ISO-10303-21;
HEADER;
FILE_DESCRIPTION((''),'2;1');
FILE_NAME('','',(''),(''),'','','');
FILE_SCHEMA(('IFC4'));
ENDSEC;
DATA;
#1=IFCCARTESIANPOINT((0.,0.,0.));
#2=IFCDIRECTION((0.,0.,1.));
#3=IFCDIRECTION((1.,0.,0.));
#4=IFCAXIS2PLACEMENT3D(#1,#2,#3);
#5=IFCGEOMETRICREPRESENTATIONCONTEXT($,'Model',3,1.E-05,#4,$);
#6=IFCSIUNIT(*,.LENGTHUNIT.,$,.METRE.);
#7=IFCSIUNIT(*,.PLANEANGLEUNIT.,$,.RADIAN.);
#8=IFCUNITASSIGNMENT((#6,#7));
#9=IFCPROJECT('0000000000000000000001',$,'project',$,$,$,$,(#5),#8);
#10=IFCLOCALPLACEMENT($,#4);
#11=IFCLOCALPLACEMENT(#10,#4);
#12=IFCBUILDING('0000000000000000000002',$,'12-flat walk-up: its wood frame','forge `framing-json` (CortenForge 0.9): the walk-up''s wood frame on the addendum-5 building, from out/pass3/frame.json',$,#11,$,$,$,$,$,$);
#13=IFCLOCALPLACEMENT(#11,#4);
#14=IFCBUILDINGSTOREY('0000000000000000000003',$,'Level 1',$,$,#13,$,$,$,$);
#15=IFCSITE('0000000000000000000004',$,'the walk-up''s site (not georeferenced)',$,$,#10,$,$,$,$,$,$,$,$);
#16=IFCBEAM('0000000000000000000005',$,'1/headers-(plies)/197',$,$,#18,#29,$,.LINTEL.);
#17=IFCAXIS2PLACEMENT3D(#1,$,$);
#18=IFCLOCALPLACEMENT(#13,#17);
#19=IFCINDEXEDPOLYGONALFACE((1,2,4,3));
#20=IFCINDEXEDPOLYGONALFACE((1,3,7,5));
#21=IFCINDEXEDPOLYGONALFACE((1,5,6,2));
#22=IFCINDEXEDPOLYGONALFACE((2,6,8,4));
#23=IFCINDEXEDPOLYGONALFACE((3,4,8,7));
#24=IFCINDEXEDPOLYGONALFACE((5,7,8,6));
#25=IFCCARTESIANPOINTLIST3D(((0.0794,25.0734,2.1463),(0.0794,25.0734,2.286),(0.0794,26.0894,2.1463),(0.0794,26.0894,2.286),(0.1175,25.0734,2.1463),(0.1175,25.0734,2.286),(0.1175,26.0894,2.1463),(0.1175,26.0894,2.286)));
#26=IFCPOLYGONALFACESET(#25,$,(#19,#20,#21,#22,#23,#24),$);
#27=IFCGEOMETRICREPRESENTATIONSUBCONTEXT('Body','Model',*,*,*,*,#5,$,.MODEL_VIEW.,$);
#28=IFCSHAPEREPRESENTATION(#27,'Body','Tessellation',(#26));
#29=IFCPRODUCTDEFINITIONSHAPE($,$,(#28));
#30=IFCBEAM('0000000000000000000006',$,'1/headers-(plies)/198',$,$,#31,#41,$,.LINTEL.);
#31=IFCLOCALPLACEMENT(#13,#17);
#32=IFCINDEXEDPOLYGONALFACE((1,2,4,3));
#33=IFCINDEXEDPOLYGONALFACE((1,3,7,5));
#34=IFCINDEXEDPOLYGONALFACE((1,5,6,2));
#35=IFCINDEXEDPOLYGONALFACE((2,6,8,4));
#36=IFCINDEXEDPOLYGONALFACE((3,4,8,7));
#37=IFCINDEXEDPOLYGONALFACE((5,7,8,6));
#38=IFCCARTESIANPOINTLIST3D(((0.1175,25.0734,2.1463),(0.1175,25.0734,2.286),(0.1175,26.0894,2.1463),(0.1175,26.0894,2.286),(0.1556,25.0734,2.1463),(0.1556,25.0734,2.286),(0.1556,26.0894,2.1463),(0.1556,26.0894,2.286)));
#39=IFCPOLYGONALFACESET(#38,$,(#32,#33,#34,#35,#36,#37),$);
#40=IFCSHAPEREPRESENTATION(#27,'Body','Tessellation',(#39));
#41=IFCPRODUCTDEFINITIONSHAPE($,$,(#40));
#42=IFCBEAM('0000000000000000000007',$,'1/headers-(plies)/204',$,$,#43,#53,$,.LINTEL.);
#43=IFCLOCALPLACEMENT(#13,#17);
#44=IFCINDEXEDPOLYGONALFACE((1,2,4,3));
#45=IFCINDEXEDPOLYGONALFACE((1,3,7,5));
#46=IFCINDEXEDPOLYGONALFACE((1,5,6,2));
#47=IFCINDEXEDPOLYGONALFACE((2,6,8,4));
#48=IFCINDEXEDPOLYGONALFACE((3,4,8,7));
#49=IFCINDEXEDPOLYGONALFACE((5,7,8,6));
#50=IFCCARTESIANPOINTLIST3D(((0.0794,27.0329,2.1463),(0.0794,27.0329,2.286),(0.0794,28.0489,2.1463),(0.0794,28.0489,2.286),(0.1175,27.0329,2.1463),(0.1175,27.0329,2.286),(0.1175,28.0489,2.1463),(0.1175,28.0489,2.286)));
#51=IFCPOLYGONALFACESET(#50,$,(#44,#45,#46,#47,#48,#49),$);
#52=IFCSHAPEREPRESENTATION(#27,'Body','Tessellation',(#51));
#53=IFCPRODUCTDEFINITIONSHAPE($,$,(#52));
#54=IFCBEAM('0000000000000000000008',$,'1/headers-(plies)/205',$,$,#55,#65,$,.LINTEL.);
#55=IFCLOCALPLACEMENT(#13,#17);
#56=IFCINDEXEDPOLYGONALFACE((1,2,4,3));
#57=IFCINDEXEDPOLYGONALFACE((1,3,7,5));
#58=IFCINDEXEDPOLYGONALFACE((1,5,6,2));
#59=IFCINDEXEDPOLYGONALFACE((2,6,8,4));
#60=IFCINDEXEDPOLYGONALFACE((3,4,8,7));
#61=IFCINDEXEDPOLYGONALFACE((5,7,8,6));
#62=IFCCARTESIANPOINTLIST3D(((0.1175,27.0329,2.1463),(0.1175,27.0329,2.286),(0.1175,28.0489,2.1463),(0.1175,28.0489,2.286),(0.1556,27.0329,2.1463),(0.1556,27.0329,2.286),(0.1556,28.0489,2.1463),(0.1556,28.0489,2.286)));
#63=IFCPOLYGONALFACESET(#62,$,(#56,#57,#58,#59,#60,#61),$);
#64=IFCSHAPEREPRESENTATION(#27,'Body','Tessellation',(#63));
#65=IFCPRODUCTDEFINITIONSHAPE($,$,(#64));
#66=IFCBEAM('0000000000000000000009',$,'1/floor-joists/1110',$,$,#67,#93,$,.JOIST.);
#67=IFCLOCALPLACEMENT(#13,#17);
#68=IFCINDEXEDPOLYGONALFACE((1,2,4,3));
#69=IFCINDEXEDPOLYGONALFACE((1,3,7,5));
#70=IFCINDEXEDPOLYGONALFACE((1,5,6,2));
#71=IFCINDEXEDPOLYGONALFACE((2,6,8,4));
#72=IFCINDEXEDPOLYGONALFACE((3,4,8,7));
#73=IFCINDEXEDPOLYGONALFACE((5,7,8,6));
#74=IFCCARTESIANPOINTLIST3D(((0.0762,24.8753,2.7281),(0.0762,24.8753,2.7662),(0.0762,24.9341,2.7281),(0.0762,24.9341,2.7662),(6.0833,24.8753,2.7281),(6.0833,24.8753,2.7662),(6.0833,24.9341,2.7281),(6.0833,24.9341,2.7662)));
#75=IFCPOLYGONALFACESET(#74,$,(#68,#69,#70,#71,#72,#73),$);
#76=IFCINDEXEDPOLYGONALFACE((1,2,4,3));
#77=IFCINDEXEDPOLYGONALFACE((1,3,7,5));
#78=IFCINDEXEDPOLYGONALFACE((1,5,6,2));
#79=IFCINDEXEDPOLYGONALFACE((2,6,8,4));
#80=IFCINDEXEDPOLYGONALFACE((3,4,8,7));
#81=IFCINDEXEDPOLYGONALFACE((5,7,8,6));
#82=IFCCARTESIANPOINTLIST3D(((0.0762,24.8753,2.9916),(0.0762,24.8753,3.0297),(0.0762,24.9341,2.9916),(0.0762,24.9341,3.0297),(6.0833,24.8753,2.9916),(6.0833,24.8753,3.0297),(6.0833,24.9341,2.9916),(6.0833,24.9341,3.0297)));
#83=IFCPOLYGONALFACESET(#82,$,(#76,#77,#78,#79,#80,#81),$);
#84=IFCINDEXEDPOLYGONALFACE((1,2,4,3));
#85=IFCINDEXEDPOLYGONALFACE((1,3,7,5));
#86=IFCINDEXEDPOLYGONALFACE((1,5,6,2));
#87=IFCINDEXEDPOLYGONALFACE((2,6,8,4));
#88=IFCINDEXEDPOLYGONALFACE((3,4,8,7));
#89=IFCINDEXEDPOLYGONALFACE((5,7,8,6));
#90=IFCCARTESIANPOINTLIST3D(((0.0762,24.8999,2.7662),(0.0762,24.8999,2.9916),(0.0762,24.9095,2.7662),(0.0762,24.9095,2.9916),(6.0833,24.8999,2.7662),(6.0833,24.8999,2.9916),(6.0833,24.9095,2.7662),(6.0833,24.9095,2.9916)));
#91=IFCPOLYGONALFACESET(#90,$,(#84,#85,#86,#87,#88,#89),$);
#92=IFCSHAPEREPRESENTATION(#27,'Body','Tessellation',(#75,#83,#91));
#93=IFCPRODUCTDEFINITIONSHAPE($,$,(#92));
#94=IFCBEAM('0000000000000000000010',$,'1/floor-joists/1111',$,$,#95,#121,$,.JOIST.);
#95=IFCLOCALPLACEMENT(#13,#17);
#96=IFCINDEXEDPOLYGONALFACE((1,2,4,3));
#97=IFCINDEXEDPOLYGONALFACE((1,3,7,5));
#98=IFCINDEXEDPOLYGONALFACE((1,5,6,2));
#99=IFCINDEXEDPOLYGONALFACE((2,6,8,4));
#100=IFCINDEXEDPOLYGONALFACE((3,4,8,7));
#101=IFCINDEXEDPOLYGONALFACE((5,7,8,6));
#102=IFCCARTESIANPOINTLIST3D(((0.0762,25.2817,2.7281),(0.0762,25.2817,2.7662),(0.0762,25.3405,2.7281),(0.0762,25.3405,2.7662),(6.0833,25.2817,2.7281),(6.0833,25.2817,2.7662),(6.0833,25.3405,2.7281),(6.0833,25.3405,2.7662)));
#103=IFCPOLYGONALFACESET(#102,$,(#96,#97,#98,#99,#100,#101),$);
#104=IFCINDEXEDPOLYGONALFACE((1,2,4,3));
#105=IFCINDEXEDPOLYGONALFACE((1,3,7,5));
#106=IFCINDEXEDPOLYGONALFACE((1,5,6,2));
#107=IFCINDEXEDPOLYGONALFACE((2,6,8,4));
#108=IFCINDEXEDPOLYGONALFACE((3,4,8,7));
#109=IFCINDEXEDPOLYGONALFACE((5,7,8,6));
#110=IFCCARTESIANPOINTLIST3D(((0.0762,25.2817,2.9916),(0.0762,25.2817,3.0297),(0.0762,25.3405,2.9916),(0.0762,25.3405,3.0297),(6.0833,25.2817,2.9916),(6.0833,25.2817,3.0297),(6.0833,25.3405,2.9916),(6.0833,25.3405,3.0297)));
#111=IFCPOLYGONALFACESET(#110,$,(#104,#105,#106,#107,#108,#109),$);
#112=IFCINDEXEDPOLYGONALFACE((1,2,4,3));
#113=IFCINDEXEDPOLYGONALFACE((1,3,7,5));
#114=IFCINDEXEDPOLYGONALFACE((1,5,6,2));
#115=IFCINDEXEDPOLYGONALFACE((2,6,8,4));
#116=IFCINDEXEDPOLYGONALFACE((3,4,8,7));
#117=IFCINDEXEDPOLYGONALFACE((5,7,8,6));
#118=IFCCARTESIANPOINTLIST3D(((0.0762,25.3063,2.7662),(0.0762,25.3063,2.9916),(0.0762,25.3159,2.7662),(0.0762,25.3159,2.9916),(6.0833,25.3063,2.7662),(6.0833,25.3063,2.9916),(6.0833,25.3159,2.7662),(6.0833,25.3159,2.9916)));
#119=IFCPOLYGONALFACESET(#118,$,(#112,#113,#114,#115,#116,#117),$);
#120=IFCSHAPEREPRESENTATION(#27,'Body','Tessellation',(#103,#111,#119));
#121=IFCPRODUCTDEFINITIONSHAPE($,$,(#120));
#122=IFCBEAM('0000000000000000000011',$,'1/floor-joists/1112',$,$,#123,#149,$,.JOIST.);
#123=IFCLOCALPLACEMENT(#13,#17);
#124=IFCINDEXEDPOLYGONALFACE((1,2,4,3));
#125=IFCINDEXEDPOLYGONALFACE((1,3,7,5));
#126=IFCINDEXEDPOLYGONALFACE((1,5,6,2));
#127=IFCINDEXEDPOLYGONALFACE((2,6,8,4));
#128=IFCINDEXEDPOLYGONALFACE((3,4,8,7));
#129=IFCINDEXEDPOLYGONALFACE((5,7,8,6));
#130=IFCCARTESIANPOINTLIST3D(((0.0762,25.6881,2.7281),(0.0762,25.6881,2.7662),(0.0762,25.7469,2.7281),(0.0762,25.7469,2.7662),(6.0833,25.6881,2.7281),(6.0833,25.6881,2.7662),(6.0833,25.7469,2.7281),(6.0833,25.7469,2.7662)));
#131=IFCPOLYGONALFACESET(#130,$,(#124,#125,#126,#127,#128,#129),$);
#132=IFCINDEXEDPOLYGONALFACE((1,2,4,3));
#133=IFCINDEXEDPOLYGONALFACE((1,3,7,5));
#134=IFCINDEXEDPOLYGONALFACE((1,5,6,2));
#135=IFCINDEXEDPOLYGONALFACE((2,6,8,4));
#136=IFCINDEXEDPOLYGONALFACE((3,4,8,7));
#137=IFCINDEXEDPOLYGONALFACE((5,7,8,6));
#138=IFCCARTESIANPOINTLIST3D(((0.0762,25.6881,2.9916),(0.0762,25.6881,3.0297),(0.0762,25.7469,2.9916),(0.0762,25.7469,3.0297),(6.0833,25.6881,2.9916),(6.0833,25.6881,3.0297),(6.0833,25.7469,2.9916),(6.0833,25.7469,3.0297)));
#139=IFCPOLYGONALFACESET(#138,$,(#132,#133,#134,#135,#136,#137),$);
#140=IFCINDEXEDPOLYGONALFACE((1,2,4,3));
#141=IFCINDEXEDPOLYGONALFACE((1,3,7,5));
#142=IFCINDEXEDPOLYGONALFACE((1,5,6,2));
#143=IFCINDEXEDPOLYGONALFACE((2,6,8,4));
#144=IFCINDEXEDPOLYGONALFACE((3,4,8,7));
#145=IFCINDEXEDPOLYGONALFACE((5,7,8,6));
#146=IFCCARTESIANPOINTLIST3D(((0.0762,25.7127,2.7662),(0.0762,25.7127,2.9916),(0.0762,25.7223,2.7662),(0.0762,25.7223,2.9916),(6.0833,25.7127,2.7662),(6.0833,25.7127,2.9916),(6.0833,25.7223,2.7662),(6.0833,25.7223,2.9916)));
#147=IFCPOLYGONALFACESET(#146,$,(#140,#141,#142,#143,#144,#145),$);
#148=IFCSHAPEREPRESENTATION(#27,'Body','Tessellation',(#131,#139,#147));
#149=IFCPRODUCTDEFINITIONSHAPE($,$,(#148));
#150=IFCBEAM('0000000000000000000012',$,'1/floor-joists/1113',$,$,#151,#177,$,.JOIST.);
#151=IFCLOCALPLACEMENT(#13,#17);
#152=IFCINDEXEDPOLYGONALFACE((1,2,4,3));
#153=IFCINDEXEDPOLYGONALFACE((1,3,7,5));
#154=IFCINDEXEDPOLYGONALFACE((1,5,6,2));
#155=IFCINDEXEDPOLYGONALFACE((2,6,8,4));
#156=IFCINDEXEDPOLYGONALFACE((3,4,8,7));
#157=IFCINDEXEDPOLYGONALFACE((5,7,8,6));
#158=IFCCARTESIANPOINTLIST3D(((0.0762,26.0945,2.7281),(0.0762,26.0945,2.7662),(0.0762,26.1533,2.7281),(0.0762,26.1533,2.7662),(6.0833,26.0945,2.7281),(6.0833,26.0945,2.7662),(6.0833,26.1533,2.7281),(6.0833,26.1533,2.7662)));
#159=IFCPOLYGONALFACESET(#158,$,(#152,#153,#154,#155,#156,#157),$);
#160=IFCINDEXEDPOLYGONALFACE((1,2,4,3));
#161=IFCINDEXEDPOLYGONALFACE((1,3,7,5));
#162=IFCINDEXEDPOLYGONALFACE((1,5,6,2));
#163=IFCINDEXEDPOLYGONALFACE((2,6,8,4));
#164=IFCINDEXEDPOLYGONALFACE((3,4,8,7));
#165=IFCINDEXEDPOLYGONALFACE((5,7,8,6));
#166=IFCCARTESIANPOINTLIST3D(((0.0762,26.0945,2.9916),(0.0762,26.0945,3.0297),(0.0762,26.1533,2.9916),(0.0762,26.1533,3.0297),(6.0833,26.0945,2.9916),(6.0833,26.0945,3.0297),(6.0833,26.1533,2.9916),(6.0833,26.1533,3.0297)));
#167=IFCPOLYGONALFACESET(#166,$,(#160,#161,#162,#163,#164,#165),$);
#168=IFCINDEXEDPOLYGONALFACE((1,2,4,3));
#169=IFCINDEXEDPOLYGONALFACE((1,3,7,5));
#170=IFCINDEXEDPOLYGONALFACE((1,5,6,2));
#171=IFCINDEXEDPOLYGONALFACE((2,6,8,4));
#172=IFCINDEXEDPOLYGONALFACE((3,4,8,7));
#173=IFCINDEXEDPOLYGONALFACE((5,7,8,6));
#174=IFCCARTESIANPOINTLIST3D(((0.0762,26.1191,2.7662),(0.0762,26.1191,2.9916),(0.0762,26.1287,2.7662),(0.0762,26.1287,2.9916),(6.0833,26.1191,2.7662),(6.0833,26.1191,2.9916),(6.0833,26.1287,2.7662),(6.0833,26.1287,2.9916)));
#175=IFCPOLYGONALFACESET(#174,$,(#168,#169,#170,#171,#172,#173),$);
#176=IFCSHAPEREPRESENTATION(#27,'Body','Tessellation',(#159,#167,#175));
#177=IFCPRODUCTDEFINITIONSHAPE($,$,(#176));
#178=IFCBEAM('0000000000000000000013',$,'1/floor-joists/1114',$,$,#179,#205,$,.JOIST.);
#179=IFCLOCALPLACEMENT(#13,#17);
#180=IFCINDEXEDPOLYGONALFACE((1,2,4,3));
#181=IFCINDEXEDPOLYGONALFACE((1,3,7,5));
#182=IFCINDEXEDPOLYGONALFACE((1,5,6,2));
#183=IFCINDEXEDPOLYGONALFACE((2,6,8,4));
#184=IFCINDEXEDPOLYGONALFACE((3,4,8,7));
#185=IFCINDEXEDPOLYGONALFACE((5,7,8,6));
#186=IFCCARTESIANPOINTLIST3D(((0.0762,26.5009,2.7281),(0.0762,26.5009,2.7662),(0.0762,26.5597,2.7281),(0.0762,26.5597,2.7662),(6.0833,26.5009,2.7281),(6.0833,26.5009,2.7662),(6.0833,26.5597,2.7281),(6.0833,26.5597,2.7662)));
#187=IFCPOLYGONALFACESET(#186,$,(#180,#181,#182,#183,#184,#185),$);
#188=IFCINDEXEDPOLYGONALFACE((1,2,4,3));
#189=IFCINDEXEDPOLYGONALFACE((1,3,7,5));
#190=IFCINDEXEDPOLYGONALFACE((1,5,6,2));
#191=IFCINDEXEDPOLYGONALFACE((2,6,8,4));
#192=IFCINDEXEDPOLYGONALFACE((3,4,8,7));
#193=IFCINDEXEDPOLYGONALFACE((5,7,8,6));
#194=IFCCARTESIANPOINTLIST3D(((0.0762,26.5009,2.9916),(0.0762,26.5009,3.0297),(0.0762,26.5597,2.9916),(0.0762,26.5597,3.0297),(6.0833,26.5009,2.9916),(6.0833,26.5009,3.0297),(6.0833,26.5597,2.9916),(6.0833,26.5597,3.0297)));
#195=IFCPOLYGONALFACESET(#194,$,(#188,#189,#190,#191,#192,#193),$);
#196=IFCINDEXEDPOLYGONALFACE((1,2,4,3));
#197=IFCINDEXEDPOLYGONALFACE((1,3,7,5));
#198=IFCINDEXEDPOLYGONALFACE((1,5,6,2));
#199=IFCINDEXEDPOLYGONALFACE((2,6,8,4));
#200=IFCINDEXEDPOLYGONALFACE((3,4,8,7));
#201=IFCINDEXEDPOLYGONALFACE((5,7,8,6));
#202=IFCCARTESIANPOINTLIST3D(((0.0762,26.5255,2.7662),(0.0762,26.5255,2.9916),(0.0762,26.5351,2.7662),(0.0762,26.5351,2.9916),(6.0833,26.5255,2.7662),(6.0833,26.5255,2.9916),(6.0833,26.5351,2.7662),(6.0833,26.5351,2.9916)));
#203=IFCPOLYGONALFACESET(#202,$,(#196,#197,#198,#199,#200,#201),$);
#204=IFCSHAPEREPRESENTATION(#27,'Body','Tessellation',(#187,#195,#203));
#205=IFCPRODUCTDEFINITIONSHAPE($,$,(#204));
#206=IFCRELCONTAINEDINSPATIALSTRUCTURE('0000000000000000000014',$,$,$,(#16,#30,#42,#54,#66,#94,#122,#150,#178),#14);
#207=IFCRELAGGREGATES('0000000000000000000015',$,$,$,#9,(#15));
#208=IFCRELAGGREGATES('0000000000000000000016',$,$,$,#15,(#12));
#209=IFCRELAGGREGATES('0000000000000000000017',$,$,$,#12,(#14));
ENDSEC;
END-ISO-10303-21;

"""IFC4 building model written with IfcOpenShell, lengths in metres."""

from ifc_helpers import new_model, si_unit, frame, frame_2d, origin, origin_with_axes, place, context, subcontext, project, spatial, rectangle, extrude, element, save


model = new_model("IFC4")

# Units and contexts
model_context = context("Model", 3, precision=1e-05, world=origin_with_axes())
body_context = subcontext(model_context, "Body", "Model", "MODEL_VIEW")
ifc_project = project(units=[si_unit("LENGTHUNIT", "METRE"), si_unit("PLANEANGLEUNIT", "RADIAN")], contexts=[model_context])

# Site, building, storey
site_placement = place(None, origin_with_axes())
site = spatial("IfcSite", under=ifc_project, at=site_placement, Name="the walk-up's site (not georeferenced)")
building_placement = place(site_placement, origin_with_axes())
building = spatial("IfcBuilding", under=site, at=building_placement, Name="12-flat walk-up: its wood frame", Description="forge `framing-json` (CortenForge 0.9): the walk-up's wood frame on the addendum-5 building, from out/pass3/frame.json")
storey_placement = place(building_placement, origin_with_axes())
storey = spatial("IfcBuildingStorey", under=building, at=storey_placement, Name="Level 1")

# Beams
for number, where, z_axis, x_axis, name in (
    (1, (0.0794, 25.0734, 2.1463), (0.0, 0.0, 1.0), (1.0, 0.0, 0.0), "1/headers-(plies)/197"),
    (2, (0.1175, 25.0734, 2.1463), (0.0, 0.0, 1.0), (1.0, 0.0, 0.0), "1/headers-(plies)/198"),
):
    element("IfcBeam", number, at=place(storey_placement, frame(where, z_axis=z_axis, x_axis=x_axis)), inside=storey, Name=name, PredefinedType="LINTEL", context=body_context, shape_type="SweptSolid", body=[
        extrude(rectangle(XDim=0.0381, YDim=1.016, at=frame_2d((0.019, 0.508))), origin(), (0.0, 0.0, 1.0), 0.1397),
    ])
for number, where, z_axis, x_axis, name in (
    (3, (0.0794, 27.0329, 2.1463), (0.0, 0.0, 1.0), (1.0, 0.0, 0.0), "1/headers-(plies)/204"),
    (4, (0.1175, 27.0329, 2.1463), (0.0, 0.0, 1.0), (1.0, 0.0, 0.0), "1/headers-(plies)/205"),
):
    element("IfcBeam", number, at=place(storey_placement, frame(where, z_axis=z_axis, x_axis=x_axis)), inside=storey, Name=name, PredefinedType="LINTEL", context=body_context, shape_type="SweptSolid", body=[
        extrude(rectangle(XDim=0.0381, YDim=1.016, at=frame_2d((0.019, 0.508))), origin(), (0.0, 0.0, 1.0), 0.1397),
    ])
beam_1_placement = place(storey_placement, frame((0.0762, 24.8753, 2.7281), z_axis=(0.0, 0.0, 1.0), x_axis=(1.0, 0.0, 0.0)))
element("IfcBeam", 5, at=beam_1_placement, inside=storey, Name="1/floor-joists/1110", PredefinedType="JOIST", context=body_context, shape_type="SweptSolid", body=[
    extrude(rectangle(XDim=6.0071, YDim=0.0587, at=frame_2d((3.0036, 0.0294))), origin(), (0.0, 0.0, 1.0), 0.0381),
    extrude(rectangle(XDim=6.0071, YDim=0.0587, at=frame_2d((3.0036, 0.0294))), frame((0.0, 0.0, 0.2635)), (0.0, 0.0, 1.0), 0.0381),
    extrude(rectangle(XDim=6.0071, YDim=0.0095, at=frame_2d((3.0036, 0.0048))), frame((0.0, 0.0246, 0.0381)), (0.0, 0.0, 1.0), 0.2254),
])
beam_2_placement = place(storey_placement, frame((0.0762, 25.2817, 2.7281), z_axis=(0.0, 0.0, 1.0), x_axis=(1.0, 0.0, 0.0)))
element("IfcBeam", 6, at=beam_2_placement, inside=storey, Name="1/floor-joists/1111", PredefinedType="JOIST", context=body_context, shape_type="SweptSolid", body=[
    extrude(rectangle(XDim=6.0071, YDim=0.0587, at=frame_2d((3.0036, 0.0294))), origin(), (0.0, 0.0, 1.0), 0.0381),
    extrude(rectangle(XDim=6.0071, YDim=0.0587, at=frame_2d((3.0036, 0.0294))), frame((0.0, 0.0, 0.2635)), (0.0, 0.0, 1.0), 0.0381),
    extrude(rectangle(XDim=6.0071, YDim=0.0095, at=frame_2d((3.0036, 0.0048))), frame((0.0, 0.0246, 0.0381)), (0.0, 0.0, 1.0), 0.2254),
])
beam_3_placement = place(storey_placement, frame((0.0762, 25.6881, 2.7281), z_axis=(0.0, 0.0, 1.0), x_axis=(1.0, 0.0, 0.0)))
element("IfcBeam", 7, at=beam_3_placement, inside=storey, Name="1/floor-joists/1112", PredefinedType="JOIST", context=body_context, shape_type="SweptSolid", body=[
    extrude(rectangle(XDim=6.0071, YDim=0.0587, at=frame_2d((3.0036, 0.0294))), origin(), (0.0, 0.0, 1.0), 0.0381),
    extrude(rectangle(XDim=6.0071, YDim=0.0587, at=frame_2d((3.0036, 0.0294))), frame((0.0, 0.0, 0.2635)), (0.0, 0.0, 1.0), 0.0381),
    extrude(rectangle(XDim=6.0071, YDim=0.0095, at=frame_2d((3.0036, 0.0048))), frame((0.0, 0.0246, 0.0381)), (0.0, 0.0, 1.0), 0.2254),
])
beam_4_placement = place(storey_placement, frame((0.0762, 26.0945, 2.7281), z_axis=(0.0, 0.0, 1.0), x_axis=(1.0, 0.0, 0.0)))
element("IfcBeam", 8, at=beam_4_placement, inside=storey, Name="1/floor-joists/1113", PredefinedType="JOIST", context=body_context, shape_type="SweptSolid", body=[
    extrude(rectangle(XDim=6.0071, YDim=0.0587, at=frame_2d((3.0036, 0.0294))), origin(), (0.0, 0.0, 1.0), 0.0381),
    extrude(rectangle(XDim=6.0071, YDim=0.0587, at=frame_2d((3.0036, 0.0294))), frame((0.0, 0.0, 0.2635)), (0.0, 0.0, 1.0), 0.0381),
    extrude(rectangle(XDim=6.0071, YDim=0.0095, at=frame_2d((3.0036, 0.0048))), frame((0.0, 0.0246, 0.0381)), (0.0, 0.0, 1.0), 0.2254),
])
beam_5_placement = place(storey_placement, frame((0.0762, 26.5009, 2.7281), z_axis=(0.0, 0.0, 1.0), x_axis=(1.0, 0.0, 0.0)))
element("IfcBeam", 9, at=beam_5_placement, inside=storey, Name="1/floor-joists/1114", PredefinedType="JOIST", context=body_context, shape_type="SweptSolid", body=[
    extrude(rectangle(XDim=6.0071, YDim=0.0587, at=frame_2d((3.0036, 0.0294))), origin(), (0.0, 0.0, 1.0), 0.0381),
    extrude(rectangle(XDim=6.0071, YDim=0.0587, at=frame_2d((3.0036, 0.0294))), frame((0.0, 0.0, 0.2635)), (0.0, 0.0, 1.0), 0.0381),
    extrude(rectangle(XDim=6.0071, YDim=0.0095, at=frame_2d((3.0036, 0.0048))), frame((0.0, 0.0246, 0.0381)), (0.0, 0.0, 1.0), 0.2254),
])

save(model, "model.ifc")
